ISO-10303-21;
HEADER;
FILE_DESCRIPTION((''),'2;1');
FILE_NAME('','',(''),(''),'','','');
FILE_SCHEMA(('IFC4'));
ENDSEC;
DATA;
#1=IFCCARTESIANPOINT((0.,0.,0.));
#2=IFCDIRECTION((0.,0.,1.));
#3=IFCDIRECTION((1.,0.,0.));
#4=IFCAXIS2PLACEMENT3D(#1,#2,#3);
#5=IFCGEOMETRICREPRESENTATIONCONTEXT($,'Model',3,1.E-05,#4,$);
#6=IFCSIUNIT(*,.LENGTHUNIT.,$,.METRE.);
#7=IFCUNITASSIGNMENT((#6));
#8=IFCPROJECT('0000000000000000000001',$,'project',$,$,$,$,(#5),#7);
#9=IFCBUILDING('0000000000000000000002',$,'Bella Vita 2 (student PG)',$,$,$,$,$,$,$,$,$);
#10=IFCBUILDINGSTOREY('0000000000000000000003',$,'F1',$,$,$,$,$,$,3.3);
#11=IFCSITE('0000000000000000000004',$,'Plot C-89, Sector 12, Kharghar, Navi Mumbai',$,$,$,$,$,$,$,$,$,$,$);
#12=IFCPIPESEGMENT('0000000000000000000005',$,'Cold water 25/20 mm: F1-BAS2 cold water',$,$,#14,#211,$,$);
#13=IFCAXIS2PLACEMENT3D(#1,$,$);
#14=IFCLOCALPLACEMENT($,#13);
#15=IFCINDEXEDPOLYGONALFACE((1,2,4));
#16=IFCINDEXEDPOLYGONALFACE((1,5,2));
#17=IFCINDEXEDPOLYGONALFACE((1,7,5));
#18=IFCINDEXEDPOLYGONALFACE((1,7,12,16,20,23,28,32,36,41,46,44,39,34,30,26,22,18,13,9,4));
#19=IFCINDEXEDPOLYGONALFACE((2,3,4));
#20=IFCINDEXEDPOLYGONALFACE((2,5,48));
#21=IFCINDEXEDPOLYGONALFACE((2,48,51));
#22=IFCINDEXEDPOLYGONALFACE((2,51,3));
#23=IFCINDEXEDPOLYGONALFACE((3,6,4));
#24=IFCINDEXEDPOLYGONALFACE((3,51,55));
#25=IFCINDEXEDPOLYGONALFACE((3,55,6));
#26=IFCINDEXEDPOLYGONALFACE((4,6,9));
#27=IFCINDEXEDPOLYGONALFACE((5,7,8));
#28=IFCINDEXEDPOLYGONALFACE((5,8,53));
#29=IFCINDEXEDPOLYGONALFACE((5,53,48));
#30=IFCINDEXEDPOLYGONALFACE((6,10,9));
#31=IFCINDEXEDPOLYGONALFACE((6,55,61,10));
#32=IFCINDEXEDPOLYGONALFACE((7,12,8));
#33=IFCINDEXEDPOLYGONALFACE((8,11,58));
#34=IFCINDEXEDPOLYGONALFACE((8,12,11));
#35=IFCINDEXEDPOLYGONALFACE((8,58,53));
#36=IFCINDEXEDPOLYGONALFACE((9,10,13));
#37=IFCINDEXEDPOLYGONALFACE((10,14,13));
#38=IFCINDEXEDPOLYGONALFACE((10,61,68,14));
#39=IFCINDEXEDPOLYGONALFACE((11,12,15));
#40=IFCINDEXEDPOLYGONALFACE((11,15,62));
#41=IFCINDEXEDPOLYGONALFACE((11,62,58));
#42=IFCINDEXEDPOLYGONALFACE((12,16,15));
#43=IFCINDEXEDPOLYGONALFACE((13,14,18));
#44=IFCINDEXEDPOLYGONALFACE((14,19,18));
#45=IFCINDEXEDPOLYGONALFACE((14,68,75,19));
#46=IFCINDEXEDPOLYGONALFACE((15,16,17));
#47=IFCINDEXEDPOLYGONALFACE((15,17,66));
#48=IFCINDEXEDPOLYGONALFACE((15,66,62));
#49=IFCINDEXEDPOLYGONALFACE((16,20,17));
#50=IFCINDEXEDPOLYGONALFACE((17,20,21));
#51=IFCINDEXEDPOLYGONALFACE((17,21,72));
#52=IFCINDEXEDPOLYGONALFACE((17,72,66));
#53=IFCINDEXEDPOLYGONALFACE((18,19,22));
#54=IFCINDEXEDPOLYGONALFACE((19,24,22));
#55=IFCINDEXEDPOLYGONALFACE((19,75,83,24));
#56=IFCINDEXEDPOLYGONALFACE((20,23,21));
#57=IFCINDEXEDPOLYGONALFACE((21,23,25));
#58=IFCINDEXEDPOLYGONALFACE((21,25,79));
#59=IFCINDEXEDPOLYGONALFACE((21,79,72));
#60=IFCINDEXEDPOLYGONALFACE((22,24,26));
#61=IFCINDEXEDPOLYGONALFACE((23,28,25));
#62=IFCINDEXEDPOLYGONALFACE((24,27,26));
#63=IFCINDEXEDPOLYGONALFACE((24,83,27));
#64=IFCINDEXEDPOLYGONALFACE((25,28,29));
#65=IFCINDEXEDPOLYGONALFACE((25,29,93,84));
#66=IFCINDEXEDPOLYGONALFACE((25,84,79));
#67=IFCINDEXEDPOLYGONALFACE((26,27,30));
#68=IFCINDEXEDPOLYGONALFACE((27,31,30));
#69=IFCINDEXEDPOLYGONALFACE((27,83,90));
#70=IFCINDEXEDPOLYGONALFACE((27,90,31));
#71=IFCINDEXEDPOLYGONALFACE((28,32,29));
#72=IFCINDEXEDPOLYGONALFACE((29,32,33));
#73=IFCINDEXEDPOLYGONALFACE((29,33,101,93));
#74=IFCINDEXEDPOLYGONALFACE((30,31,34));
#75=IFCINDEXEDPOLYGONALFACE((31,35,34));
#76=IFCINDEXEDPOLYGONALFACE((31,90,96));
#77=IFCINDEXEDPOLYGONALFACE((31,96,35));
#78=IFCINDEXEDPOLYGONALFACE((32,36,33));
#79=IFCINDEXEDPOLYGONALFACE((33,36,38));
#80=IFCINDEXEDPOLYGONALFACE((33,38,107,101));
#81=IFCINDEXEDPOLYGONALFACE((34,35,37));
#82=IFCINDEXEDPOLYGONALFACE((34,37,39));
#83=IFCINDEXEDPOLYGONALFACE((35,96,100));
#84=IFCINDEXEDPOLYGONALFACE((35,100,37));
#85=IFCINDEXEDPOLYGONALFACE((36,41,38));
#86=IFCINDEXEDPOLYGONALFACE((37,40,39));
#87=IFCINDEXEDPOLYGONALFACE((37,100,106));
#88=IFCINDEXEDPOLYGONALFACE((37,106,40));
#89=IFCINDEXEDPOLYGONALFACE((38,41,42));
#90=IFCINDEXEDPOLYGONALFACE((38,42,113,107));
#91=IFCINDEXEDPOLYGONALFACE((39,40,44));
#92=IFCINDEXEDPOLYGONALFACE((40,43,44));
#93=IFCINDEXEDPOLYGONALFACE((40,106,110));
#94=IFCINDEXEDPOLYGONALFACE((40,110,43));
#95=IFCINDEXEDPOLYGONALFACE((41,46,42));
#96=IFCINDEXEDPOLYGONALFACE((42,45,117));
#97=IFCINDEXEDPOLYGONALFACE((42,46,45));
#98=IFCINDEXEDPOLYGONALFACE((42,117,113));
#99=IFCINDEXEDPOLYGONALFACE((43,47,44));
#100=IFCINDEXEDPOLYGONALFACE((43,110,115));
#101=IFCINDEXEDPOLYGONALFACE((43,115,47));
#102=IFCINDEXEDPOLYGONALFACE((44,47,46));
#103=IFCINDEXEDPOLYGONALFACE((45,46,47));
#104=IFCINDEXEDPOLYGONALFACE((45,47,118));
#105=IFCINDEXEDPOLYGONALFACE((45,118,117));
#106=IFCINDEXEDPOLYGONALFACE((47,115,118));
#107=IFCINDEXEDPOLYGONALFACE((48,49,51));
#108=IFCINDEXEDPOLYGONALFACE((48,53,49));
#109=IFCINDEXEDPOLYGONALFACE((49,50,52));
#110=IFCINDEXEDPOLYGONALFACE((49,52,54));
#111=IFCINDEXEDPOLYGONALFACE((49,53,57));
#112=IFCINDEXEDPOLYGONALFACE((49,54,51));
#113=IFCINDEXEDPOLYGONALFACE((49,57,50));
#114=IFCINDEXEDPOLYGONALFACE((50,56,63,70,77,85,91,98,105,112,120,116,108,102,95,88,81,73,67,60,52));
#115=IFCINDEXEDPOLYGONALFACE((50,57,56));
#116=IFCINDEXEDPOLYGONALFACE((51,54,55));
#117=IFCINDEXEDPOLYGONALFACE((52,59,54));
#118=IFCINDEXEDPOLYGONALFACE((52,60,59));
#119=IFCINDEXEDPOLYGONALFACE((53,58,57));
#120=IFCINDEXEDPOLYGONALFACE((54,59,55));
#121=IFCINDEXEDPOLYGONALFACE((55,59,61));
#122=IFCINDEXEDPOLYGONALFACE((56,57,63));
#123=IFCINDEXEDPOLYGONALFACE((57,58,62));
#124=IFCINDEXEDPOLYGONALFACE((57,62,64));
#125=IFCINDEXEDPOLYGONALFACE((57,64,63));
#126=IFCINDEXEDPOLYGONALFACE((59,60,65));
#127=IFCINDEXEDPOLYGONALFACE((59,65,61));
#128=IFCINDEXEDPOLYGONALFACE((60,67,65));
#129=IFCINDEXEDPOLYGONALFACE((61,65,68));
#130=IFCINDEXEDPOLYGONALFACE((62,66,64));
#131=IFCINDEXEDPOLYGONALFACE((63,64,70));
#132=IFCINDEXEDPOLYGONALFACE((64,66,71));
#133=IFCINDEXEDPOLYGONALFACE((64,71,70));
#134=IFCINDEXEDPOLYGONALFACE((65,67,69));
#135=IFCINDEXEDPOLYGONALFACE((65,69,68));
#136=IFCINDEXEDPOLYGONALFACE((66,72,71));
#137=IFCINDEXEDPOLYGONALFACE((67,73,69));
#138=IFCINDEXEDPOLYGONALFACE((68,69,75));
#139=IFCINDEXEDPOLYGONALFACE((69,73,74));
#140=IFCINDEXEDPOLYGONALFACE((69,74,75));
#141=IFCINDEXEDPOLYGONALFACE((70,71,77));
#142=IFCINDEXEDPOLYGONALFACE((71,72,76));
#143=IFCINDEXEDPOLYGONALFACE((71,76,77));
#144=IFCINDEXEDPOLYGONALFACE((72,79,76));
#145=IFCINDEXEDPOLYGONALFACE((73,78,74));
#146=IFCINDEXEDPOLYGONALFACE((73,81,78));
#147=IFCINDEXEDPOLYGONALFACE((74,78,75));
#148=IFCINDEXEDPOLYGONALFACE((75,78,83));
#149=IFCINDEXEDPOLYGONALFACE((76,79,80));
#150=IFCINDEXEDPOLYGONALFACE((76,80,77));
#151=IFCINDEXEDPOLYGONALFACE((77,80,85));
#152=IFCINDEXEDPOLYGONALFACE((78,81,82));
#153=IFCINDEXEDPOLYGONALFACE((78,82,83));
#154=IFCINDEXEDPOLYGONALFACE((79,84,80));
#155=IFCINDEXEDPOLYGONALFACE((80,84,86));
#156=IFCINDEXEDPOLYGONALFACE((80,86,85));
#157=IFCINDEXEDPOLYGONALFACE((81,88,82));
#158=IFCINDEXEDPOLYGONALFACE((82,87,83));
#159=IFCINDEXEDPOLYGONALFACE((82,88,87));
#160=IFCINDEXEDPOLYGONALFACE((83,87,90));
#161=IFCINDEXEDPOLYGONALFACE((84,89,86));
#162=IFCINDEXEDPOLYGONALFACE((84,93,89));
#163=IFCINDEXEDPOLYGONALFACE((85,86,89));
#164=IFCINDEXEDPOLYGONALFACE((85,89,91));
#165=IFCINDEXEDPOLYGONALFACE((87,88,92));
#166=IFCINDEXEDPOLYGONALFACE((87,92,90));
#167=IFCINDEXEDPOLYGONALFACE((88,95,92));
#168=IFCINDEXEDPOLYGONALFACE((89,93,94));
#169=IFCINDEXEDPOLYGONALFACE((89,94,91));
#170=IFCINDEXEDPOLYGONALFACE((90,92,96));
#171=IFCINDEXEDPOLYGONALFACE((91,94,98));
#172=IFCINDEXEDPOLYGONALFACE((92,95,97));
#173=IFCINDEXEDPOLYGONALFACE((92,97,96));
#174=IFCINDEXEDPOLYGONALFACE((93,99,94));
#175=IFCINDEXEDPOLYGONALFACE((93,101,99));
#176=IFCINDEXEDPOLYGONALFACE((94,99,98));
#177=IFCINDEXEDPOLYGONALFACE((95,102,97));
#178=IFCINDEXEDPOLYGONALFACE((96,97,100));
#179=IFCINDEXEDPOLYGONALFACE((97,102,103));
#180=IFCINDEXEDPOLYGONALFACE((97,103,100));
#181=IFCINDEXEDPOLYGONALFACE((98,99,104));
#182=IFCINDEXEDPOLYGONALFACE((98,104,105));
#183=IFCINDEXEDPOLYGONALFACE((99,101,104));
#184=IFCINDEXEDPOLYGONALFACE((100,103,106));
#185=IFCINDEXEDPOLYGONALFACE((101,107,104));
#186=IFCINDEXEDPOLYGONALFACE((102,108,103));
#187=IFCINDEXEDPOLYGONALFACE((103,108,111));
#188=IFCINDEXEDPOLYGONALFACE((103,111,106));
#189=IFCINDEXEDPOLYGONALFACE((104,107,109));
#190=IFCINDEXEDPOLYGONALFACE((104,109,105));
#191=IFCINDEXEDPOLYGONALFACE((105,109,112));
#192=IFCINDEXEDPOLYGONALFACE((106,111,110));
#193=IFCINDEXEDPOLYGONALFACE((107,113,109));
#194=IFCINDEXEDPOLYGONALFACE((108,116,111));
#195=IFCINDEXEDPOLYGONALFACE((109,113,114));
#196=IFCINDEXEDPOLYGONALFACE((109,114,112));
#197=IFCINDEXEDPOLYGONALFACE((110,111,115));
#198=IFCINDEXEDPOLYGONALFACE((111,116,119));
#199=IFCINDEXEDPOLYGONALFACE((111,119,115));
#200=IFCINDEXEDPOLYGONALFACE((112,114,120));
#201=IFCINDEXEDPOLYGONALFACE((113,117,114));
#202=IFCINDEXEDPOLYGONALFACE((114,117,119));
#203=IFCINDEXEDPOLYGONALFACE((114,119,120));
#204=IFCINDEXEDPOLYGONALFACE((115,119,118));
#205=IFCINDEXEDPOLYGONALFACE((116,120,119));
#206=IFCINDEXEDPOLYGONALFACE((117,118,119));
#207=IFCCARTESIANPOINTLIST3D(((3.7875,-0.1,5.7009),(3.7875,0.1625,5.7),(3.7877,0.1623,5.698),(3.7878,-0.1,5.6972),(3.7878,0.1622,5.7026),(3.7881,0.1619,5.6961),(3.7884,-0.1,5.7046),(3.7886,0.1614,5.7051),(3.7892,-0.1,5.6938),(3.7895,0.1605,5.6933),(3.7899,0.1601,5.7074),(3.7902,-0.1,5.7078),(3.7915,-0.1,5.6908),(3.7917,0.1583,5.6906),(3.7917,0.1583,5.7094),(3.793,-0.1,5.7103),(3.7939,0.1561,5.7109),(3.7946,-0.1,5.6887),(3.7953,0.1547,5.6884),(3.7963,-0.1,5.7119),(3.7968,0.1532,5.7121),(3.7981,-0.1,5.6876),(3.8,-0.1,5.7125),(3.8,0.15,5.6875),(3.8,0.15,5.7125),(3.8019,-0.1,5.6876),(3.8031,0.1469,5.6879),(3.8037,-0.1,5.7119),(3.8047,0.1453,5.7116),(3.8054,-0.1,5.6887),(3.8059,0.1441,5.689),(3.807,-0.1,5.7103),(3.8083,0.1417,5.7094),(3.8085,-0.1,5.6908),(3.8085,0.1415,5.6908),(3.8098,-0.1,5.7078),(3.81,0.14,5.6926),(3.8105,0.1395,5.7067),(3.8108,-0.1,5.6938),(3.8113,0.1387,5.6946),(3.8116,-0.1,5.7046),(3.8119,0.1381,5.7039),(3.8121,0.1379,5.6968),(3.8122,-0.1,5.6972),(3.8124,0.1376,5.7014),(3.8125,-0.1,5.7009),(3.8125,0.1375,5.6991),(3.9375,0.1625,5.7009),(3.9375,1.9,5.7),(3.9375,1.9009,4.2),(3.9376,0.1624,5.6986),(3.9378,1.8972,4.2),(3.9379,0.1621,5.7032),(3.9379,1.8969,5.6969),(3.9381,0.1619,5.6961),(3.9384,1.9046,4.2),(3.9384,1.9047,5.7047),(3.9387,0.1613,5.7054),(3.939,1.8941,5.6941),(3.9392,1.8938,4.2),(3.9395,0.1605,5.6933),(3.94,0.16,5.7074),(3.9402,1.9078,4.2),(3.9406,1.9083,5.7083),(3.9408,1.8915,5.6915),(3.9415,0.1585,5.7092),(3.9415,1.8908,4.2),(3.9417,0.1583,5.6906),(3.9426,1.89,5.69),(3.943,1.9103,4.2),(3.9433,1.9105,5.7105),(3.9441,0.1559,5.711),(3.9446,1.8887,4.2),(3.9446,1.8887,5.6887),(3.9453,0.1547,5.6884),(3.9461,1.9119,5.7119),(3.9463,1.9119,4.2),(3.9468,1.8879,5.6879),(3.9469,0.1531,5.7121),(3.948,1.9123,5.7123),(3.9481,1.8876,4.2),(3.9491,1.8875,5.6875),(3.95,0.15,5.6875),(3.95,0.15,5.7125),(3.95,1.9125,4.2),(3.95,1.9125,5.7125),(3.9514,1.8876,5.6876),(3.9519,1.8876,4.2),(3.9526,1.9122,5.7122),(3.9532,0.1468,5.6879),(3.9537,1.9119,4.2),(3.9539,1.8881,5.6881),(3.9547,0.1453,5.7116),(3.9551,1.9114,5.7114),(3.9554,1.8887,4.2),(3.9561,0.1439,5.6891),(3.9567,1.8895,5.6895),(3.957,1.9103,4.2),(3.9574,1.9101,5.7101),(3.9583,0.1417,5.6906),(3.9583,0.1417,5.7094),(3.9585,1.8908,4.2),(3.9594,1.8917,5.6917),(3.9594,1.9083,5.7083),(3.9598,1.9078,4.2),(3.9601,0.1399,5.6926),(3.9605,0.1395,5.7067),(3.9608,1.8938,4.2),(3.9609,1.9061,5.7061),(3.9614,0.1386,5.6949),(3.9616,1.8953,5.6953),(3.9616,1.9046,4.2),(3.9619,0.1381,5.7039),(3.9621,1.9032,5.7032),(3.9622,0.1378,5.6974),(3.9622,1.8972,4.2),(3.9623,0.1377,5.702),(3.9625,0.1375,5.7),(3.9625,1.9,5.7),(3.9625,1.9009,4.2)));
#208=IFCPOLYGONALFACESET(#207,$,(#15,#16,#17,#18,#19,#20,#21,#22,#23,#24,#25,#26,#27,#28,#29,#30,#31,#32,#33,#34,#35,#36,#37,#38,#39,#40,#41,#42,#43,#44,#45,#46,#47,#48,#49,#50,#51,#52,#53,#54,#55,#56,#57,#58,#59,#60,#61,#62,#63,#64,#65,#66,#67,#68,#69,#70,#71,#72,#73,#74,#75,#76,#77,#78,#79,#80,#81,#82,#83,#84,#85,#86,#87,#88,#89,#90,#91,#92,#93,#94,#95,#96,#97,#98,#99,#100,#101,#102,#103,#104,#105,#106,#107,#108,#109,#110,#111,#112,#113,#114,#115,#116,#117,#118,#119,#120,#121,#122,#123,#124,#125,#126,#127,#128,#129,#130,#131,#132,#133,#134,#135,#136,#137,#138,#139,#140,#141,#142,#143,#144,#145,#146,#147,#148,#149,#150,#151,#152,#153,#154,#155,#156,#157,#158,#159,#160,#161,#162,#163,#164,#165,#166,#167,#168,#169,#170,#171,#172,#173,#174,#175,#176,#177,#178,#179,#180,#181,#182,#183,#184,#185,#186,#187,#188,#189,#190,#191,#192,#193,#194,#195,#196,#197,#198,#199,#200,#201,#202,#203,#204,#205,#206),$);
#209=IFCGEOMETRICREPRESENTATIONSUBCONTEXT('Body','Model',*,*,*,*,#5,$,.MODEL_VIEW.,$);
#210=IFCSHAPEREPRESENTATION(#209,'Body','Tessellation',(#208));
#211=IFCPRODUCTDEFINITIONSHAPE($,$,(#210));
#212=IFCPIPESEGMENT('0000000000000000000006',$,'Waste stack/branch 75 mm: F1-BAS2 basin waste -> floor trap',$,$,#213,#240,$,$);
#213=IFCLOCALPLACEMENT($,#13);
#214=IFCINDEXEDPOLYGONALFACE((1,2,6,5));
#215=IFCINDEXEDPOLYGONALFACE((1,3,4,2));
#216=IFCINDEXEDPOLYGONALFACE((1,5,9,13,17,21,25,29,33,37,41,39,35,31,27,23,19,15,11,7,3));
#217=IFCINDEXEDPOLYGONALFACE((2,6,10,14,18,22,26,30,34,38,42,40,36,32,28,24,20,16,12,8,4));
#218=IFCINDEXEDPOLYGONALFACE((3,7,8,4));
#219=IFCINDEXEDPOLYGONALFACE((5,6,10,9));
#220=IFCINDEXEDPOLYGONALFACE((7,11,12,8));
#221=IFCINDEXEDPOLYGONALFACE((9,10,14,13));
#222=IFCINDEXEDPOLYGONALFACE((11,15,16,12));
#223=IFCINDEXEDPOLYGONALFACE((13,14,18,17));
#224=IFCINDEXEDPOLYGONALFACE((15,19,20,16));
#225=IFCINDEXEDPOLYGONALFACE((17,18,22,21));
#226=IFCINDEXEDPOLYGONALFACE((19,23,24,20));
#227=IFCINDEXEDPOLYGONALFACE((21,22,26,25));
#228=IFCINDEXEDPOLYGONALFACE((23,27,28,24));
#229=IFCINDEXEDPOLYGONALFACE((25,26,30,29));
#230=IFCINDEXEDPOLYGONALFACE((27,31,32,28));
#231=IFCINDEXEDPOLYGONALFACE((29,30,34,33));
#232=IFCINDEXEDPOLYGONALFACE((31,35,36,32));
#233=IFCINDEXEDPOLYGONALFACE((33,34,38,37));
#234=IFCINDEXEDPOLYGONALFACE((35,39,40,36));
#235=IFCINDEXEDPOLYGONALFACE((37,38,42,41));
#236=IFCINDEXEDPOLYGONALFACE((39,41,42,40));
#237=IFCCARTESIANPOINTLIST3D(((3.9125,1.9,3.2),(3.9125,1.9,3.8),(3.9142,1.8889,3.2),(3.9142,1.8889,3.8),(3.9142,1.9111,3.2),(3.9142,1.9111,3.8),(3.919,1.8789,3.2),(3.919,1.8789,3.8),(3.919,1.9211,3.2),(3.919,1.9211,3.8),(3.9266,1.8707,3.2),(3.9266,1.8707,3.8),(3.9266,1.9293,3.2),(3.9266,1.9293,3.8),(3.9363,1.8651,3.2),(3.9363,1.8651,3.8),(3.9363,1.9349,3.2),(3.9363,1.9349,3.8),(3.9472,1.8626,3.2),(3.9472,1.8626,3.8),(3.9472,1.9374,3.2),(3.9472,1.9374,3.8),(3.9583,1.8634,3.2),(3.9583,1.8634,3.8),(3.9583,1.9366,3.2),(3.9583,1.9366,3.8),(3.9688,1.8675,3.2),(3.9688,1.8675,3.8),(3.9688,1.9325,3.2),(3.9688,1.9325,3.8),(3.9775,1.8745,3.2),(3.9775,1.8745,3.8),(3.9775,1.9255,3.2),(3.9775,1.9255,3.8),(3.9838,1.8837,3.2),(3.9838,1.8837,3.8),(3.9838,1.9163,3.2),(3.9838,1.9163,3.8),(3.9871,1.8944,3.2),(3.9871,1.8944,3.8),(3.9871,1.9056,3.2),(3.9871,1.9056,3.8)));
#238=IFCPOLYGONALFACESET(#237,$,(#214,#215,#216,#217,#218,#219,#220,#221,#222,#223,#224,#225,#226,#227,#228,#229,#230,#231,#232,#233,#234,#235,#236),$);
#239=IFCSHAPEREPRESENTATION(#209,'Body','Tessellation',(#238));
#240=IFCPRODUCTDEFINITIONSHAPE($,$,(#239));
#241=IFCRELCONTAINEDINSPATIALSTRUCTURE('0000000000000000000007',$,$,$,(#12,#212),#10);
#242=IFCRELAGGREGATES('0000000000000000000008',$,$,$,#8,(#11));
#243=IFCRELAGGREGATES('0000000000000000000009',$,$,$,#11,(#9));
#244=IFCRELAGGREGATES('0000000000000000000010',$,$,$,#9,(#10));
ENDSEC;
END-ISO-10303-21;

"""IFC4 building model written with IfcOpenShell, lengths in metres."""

from ifc_helpers import new_model, entity, si_unit, origin, origin_with_axes, place, context, subcontext, project, spatial, element, save


model = new_model("IFC4")

# Units and contexts
model_context = context("Model", 3, precision=1e-05, world=origin_with_axes())
body_context = subcontext(model_context, "Body", "Model", "MODEL_VIEW")
ifc_project = project(units=[si_unit("LENGTHUNIT", "METRE")], contexts=[model_context])

# Site, building, storey
site = spatial("IfcSite", under=ifc_project, Name="Plot C-89, Sector 12, Kharghar, Navi Mumbai")
building = spatial("IfcBuilding", under=site, Name="Bella Vita 2 (student PG)")
storey = spatial("IfcBuildingStorey", under=building, Name="F1", Elevation=3.3)

# Pipe segments
pipe_segment_1_placement = place(None, origin())
element("IfcPipeSegment", 1, at=pipe_segment_1_placement, inside=storey, Name="Cold water 25/20 mm: F1-BAS2 cold water", context=body_context, shape_type="AdvancedSweptSolid", body=[
    entity("IfcSweptDiskSolid", entity("IfcPolyline", [entity("IfcCartesianPoint", [3.8, -0.1, 5.7]), entity("IfcCartesianPoint", [3.8, 0.15, 5.7]), entity("IfcCartesianPoint", [3.95, 0.15, 5.7]), entity("IfcCartesianPoint", [3.95, 1.9, 5.7]), entity("IfcCartesianPoint", [3.95, 1.9, 4.2])]), 0.0125),
])
pipe_segment_2_placement = place(None, origin())
element("IfcPipeSegment", 2, at=pipe_segment_2_placement, inside=storey, Name="Waste stack/branch 75 mm: F1-BAS2 basin waste -> floor trap", context=body_context, shape_type="AdvancedSweptSolid", body=[
    entity("IfcSweptDiskSolid", entity("IfcPolyline", [entity("IfcCartesianPoint", [3.95, 1.9, 3.8]), entity("IfcCartesianPoint", [3.95, 1.9, 3.2])]), 0.0375),
])

save(model, "model.ifc")
